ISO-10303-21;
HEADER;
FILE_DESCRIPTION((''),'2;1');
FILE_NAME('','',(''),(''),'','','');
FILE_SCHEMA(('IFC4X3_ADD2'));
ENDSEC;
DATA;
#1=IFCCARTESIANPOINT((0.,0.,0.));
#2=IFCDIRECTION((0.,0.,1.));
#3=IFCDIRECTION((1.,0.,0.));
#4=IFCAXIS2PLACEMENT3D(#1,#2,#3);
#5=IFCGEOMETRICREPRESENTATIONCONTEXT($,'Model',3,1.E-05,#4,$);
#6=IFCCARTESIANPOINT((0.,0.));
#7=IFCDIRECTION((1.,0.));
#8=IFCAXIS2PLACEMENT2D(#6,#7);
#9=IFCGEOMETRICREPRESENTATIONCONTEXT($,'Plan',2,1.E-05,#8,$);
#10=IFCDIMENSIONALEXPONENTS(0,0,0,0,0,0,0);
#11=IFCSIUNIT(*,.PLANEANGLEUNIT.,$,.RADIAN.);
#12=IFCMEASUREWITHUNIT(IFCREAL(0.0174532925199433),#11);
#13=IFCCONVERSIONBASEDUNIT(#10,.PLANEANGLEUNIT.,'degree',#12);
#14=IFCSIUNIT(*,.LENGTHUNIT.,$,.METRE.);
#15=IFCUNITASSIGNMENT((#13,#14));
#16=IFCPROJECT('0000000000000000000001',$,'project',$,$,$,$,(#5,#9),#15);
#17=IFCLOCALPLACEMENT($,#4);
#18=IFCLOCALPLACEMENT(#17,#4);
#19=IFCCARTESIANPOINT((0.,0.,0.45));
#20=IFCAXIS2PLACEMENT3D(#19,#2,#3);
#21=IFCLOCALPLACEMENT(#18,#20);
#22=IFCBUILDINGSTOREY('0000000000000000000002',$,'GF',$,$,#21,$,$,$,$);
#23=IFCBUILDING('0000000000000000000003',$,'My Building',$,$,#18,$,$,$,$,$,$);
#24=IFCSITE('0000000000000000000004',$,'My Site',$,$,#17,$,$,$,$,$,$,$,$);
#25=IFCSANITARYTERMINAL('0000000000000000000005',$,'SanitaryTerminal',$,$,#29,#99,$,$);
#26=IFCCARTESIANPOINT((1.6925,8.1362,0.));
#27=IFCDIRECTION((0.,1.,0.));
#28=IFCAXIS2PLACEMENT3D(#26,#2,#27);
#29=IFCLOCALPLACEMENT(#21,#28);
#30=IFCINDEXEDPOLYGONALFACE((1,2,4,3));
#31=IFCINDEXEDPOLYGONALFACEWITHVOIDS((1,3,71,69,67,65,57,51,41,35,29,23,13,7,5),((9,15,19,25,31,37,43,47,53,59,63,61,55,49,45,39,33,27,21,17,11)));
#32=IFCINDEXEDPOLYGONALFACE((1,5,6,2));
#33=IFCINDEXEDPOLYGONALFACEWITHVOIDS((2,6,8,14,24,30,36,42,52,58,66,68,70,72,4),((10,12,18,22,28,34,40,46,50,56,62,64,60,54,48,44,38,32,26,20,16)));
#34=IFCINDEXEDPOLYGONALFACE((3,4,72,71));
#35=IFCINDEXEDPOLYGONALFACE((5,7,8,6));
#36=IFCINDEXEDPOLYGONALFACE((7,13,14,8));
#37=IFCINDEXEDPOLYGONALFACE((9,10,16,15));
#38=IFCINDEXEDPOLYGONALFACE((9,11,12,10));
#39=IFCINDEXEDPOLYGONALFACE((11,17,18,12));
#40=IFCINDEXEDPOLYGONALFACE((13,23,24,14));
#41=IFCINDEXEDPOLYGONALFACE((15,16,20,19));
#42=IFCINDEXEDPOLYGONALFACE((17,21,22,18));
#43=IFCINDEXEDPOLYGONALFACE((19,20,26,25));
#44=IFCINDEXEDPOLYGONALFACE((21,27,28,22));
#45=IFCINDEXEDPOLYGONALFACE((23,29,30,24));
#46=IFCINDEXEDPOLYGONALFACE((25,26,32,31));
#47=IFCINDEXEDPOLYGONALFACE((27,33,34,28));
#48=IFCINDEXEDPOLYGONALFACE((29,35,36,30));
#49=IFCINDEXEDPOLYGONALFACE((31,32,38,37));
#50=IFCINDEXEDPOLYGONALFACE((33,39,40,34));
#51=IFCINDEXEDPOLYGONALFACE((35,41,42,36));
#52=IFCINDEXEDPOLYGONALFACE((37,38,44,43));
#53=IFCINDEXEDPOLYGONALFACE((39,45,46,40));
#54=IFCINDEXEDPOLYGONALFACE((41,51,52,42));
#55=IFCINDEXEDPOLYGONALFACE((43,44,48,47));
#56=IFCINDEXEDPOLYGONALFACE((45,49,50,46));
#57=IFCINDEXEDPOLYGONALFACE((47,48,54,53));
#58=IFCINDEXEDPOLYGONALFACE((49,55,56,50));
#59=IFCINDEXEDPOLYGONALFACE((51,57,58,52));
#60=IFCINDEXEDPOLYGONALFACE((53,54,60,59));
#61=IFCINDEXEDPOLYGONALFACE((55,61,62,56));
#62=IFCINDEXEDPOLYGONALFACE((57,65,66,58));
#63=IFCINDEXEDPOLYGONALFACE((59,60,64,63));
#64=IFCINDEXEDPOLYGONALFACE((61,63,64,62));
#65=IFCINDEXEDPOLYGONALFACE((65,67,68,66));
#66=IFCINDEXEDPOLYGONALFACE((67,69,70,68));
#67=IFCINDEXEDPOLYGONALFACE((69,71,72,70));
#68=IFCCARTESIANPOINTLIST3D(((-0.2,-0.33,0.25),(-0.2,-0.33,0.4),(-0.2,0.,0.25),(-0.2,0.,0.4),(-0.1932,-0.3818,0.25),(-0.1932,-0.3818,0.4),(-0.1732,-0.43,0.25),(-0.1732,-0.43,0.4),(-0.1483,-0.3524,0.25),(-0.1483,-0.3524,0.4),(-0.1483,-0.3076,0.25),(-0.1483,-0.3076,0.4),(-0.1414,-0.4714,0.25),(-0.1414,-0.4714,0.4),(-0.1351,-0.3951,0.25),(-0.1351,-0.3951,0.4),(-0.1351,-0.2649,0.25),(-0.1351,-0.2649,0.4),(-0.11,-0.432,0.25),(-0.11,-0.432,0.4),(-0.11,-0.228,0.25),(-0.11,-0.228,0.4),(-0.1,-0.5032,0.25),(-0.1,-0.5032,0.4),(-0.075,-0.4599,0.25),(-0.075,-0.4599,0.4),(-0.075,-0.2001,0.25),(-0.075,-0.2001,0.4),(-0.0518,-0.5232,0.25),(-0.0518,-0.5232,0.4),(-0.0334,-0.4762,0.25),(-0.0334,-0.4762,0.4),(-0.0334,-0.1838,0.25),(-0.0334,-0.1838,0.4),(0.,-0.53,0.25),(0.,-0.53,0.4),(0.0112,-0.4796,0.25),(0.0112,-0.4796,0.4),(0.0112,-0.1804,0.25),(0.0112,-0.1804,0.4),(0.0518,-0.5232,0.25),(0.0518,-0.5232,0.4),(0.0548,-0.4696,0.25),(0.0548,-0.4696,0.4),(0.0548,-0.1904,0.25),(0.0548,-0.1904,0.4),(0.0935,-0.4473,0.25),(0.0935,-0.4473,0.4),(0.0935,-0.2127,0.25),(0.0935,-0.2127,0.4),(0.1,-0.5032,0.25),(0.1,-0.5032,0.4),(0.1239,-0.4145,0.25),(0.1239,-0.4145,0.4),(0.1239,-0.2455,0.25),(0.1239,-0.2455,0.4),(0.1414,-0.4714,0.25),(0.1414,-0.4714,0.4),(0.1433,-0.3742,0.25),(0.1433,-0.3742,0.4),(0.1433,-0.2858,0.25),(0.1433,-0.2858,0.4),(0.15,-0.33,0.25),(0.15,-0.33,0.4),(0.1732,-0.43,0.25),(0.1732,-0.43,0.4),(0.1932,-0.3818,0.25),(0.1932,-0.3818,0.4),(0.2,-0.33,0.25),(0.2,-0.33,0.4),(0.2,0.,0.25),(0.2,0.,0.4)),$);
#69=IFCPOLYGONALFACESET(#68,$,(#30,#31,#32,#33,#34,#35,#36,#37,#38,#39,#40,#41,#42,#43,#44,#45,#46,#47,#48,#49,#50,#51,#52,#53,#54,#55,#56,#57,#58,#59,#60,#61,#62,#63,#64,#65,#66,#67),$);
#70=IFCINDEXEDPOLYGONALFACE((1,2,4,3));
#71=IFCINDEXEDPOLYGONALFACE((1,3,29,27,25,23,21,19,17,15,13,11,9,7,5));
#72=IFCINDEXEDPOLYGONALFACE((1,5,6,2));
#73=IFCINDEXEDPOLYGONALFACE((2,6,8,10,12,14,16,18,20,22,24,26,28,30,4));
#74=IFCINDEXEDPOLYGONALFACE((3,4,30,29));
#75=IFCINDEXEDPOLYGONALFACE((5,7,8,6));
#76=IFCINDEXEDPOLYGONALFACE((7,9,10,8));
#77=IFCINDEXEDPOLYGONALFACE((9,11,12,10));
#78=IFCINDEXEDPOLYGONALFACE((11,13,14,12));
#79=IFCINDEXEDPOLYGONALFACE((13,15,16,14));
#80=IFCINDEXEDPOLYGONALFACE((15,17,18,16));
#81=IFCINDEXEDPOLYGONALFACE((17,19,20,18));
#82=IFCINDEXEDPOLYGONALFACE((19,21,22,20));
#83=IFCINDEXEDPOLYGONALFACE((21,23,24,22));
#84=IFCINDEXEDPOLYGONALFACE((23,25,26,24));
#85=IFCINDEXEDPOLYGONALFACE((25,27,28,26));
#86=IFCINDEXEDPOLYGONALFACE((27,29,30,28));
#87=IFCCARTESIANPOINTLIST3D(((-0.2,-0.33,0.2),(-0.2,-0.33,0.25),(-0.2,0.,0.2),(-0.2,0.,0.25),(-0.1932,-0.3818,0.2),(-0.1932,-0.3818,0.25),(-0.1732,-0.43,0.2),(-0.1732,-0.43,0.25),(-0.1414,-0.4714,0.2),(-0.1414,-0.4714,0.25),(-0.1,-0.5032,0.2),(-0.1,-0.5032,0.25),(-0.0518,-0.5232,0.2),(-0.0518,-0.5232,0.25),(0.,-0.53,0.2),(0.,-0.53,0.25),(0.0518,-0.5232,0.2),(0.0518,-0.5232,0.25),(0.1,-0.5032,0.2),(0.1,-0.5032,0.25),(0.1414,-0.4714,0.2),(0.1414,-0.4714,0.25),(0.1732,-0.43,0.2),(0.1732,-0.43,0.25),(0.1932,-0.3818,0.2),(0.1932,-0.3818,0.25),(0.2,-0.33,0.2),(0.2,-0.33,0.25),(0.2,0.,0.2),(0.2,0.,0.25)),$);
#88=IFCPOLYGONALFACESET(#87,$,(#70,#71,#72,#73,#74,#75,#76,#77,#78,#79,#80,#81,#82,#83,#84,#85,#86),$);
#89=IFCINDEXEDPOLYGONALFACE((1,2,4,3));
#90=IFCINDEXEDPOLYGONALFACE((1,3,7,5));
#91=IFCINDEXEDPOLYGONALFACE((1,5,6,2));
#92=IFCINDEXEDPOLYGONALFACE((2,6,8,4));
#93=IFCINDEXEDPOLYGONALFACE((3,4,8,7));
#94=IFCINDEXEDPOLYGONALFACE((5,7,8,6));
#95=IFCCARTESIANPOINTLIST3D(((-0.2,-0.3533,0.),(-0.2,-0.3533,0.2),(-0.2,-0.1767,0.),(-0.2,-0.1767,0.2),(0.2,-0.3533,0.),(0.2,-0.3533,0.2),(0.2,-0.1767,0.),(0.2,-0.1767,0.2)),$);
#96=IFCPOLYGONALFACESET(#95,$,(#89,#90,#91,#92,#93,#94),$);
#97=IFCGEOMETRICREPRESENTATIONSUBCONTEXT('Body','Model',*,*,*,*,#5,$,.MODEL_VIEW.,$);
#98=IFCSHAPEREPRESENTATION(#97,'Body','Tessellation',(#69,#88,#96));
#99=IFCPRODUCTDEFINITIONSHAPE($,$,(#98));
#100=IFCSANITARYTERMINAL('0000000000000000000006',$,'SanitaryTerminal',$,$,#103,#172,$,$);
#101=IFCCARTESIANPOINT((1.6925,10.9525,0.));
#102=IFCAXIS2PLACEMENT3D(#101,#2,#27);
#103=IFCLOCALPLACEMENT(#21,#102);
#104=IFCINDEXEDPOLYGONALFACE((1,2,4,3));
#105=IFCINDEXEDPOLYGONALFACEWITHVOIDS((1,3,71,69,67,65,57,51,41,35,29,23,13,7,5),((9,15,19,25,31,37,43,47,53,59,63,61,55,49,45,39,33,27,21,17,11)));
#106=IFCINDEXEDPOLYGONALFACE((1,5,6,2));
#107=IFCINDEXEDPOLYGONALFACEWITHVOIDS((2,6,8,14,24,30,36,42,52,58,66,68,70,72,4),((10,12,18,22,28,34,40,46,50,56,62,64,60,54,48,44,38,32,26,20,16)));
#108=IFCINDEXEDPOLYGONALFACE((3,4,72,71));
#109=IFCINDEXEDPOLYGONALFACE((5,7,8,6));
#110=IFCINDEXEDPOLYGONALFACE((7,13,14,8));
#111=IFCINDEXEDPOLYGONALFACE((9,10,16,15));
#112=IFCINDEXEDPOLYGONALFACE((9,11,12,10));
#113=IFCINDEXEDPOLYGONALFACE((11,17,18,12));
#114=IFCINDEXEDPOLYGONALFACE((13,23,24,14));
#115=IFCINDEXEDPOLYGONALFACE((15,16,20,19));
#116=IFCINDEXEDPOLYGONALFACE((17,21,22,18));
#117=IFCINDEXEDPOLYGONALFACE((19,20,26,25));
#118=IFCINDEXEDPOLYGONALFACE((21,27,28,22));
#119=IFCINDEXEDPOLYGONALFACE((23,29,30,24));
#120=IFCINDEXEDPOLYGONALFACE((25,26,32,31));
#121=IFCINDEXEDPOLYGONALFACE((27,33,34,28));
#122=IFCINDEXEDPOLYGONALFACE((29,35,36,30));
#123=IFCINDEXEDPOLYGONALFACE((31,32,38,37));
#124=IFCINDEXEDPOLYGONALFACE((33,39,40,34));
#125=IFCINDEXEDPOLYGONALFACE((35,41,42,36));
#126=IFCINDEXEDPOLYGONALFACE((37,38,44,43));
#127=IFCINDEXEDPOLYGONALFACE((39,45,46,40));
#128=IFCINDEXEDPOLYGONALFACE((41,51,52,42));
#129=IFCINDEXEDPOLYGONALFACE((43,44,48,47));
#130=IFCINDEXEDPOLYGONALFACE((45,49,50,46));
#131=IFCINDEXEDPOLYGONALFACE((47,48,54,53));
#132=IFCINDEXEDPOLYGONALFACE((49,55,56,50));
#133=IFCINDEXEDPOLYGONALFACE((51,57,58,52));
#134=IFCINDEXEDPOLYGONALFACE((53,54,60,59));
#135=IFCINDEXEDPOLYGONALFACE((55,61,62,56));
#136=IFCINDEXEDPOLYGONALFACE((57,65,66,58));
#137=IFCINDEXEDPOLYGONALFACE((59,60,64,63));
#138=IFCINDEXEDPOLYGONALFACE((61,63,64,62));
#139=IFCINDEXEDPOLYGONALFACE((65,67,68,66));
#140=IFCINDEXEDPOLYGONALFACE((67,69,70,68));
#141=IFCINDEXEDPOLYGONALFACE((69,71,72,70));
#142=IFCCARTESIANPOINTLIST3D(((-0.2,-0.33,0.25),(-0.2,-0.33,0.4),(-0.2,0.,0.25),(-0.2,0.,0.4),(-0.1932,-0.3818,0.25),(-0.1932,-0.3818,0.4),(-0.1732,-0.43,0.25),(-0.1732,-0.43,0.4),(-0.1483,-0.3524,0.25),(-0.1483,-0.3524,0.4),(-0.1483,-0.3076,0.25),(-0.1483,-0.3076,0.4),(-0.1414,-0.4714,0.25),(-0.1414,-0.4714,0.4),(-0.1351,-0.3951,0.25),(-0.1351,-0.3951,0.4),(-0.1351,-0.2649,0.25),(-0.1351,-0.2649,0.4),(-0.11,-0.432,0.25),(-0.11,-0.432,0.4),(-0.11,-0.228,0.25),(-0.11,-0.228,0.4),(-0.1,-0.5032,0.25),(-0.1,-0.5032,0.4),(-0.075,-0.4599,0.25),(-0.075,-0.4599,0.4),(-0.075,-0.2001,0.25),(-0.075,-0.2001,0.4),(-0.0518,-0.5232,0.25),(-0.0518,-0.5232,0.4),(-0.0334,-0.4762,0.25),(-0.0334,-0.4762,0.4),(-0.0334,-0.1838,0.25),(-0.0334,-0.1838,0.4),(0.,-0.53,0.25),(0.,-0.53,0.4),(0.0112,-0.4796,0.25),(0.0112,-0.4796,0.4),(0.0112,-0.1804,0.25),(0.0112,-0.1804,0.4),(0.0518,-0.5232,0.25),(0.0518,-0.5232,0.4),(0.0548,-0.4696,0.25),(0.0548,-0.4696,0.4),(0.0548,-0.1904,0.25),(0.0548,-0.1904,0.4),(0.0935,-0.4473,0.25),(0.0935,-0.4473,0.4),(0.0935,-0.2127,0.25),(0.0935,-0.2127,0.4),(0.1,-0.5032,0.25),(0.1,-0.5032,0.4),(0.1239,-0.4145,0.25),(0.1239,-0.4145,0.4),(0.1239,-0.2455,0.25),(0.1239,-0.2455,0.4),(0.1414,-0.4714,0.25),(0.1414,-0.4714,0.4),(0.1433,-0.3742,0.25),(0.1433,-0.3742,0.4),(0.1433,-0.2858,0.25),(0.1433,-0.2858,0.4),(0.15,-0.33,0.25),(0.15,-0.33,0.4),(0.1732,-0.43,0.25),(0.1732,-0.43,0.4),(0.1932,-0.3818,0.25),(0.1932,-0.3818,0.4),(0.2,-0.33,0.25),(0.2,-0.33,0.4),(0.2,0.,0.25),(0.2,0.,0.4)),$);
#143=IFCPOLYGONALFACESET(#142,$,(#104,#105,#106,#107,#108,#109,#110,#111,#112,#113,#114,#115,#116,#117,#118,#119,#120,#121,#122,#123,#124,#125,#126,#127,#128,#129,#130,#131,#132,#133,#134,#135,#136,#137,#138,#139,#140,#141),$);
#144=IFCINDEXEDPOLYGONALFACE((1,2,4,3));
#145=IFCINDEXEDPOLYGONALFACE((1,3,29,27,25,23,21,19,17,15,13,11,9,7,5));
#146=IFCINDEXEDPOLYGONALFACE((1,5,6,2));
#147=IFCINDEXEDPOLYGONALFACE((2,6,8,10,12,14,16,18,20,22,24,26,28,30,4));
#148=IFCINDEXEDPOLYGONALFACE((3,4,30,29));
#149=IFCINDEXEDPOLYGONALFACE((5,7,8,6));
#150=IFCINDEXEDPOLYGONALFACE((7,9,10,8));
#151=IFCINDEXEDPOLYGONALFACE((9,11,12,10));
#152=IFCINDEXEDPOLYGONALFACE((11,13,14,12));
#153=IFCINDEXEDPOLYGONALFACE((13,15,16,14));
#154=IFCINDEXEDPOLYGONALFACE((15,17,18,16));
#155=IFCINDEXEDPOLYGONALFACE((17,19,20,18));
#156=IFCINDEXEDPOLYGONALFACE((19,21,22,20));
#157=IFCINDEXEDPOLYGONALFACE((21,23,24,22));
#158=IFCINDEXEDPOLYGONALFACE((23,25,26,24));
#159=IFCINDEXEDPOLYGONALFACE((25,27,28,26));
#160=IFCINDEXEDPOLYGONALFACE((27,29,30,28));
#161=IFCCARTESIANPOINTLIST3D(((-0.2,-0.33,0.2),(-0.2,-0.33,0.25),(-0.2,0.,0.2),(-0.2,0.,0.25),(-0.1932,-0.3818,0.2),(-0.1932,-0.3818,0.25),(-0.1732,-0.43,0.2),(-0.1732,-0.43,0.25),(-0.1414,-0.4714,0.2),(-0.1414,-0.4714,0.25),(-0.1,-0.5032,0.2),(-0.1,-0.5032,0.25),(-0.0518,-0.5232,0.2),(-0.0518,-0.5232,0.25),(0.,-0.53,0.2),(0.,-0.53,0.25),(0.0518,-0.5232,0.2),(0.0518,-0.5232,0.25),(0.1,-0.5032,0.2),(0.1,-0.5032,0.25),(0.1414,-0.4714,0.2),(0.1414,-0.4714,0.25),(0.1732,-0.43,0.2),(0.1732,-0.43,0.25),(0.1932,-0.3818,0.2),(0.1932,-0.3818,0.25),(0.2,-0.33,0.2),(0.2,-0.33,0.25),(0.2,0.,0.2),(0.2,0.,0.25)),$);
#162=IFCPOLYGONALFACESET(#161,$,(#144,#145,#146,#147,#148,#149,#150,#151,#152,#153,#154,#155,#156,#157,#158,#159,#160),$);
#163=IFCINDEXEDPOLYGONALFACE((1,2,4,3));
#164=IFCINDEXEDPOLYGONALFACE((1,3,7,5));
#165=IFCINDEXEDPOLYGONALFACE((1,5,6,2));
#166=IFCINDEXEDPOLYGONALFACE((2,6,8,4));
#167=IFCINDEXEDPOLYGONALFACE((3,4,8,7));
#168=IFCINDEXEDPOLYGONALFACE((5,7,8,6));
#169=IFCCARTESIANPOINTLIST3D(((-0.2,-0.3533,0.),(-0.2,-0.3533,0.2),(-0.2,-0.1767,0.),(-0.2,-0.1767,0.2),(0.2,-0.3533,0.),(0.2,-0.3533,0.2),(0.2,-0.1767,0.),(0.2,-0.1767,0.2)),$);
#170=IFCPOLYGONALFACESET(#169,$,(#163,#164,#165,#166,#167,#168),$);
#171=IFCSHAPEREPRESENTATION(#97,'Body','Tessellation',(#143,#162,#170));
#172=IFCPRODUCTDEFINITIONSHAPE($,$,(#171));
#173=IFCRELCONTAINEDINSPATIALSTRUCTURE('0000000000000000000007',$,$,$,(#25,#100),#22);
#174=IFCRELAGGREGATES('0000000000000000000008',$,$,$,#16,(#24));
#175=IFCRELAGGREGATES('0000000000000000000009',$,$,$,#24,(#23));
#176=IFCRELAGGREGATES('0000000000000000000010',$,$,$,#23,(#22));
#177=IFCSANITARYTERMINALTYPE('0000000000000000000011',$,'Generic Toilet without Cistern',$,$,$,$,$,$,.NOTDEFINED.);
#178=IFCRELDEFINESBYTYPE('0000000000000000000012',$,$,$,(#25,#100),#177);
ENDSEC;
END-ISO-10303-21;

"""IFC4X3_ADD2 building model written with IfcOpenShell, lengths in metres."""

from ifc_helpers import new_model, entity, si_unit, converted_unit, frame, frame_2d, origin_with_axes, origin_2d_with_axis, place, context, subcontext, project, spatial, line, arc, indexed_curve, circle_curve, outline, extrude, shape, source, transform, mapped, type_object, type_shapes, element, save


model = new_model("IFC4X3_ADD2")

# Units and contexts
model_context = context("Model", 3, precision=1e-05, world=origin_with_axes())
plan_context = context("Plan", 2, precision=1e-05, world=origin_2d_with_axis())
body_context_1 = subcontext(model_context, "Body", "Model", "MODEL_VIEW")
body_context_2 = subcontext(plan_context, "Body", "Plan", "PLAN_VIEW")
ifc_project = project(units=[converted_unit("PLANEANGLEUNIT", "degree", entity("IfcReal", 0.0174532925199433), si_unit("PLANEANGLEUNIT", "RADIAN"), dimensions=[0, 0, 0, 0, 0, 0, 0]), si_unit("LENGTHUNIT", "METRE")], contexts=[model_context, plan_context])

# Site, building, storey
site_placement = place(None, origin_with_axes())
site = spatial("IfcSite", under=ifc_project, at=site_placement, Name="My Site")
building_placement = place(site_placement, origin_with_axes())
building = spatial("IfcBuilding", under=site, at=building_placement, Name="My Building")
storey_placement = place(building_placement, frame((0.0, 0.0, 0.45), z_axis=(0.0, 0.0, 1.0), x_axis=(1.0, 0.0, 0.0)))
storey = spatial("IfcBuildingStorey", under=building, at=storey_placement, Name="GF")

# Sanitary terminals
sanitary_terminal_type_1 = type_object("IfcSanitaryTerminalType", Name="Generic Toilet without Cistern", PredefinedType="NOTDEFINED")
shared_shape_1 = source(origin_with_axes(), body_context_1, "Body", "SweptSolid", [
    extrude(outline(indexed_curve([(-0.2, 0.0), (0.2, 0.0), (0.2, -0.33), (0.1414, -0.4714), (0.0, -0.53), (-0.1414, -0.4714), (-0.2, -0.33)], segments=[line(1, 2), line(2, 3), arc(3, 4, 5), arc(5, 6, 7), line(7, 1)]), holes=[circle_curve(frame_2d((0.0, -0.33)), 0.15)]), frame((0.0, 0.0, 0.25), z_axis=(0.0, 0.0, 1.0), x_axis=(1.0, 0.0, 0.0)), (0.0, 0.0, 1.0), 0.15),
    extrude(outline(indexed_curve([(-0.2, 0.0), (0.2, 0.0), (0.2, -0.33), (0.1414, -0.4714), (0.0, -0.53), (-0.1414, -0.4714), (-0.2, -0.33)], segments=[line(1, 2), line(2, 3), arc(3, 4, 5), arc(5, 6, 7), line(7, 1)])), frame((0.0, 0.0, 0.2), z_axis=(0.0, 0.0, 1.0), x_axis=(1.0, 0.0, 0.0)), (0.0, 0.0, 1.0), 0.05),
    extrude(outline(indexed_curve([(-0.2, -0.1767), (0.2, -0.1767), (0.2, -0.3533), (-0.2, -0.3533)], segments=[line(1, 2, 3, 4, 1)])), origin_with_axes(), (0.0, 0.0, 1.0), 0.2),
])
shared_shape_2 = source(origin_with_axes(), body_context_2, "Body", "Annotation2D", [
    entity("IfcGeometricCurveSet", [entity("IfcIndexedPolyCurve", entity("IfcCartesianPointList2D", [[-0.1068, -0.124], [-0.0957, -0.1129], [-0.0804, -0.1088], [0.0804, -0.1088], [0.0957, -0.1129], [0.1068, -0.124], [0.1109, -0.1393], [0.1109, -0.3476], [0.1025, -0.3926], [0.0784, -0.4308], [0.0424, -0.4563], [0.0, -0.4652], [-0.0424, -0.4563], [-0.0784, -0.4308], [-0.1025, -0.3926], [-0.1109, -0.3476], [-0.1109, -0.1393]]), [entity("IfcLineIndex", [1, 2, 3, 4, 5, 6, 7, 8, 9, 10, 11, 12, 13, 14, 15, 16, 17, 1])]), entity("IfcIndexedPolyCurve", entity("IfcCartesianPointList2D", [[-0.1962, -0.2314], [-0.1848, -0.301], [-0.1764, -0.3339], [-0.1663, -0.3651], [-0.1546, -0.3944], [-0.1414, -0.4213], [-0.1269, -0.4458], [-0.1111, -0.4675], [-0.0943, -0.4862], [-0.0765, -0.5018], [-0.0581, -0.514], [-0.039, -0.5229], [-0.0196, -0.5282], [0.0, -0.53], [0.0196, -0.5282], [0.039, -0.5229], [0.0581, -0.514], [0.0765, -0.5018], [0.0943, -0.4862], [0.1111, -0.4675], [0.1269, -0.4458], [0.1414, -0.4213], [0.1546, -0.3944], [0.1663, -0.3651], [0.1764, -0.3339], [0.1848, -0.301], [0.1962, -0.2314], [0.2, -0.159], [0.1872, 0.0], [-0.1872, 0.0], [-0.2, -0.159]]), [entity("IfcLineIndex", [1, 2, 3, 4, 5, 6, 7, 8, 9, 10, 11, 12, 13, 14, 15, 16, 17, 18, 19, 20, 21, 22, 23, 24, 25, 26, 27, 28, 29, 30, 31, 1])])]),
])
type_shapes(sanitary_terminal_type_1, [shared_shape_1, shared_shape_2])
for number, where, z_axis, x_axis, name in (
    (1, (1.6925, 8.1362, 0.0), (0.0, 0.0, 1.0), (0.0, 1.0, 0.0), "SanitaryTerminal"),
    (2, (1.6925, 10.9525, 0.0), (0.0, 0.0, 1.0), (0.0, 1.0, 0.0), "SanitaryTerminal"),
):
    element("IfcSanitaryTerminal", number, at=place(storey_placement, frame(where, z_axis=z_axis, x_axis=x_axis)), inside=storey, type_object=sanitary_terminal_type_1, Name=name, shapes=[
        shape(body_context_1, "Body", "MappedRepresentation", [mapped(shared_shape_1, transform((0.0, 0.0, 0.0), x_axis=(1.0, 0.0, 0.0), y_axis=(0.0, 1.0, 0.0), z_axis=(0.0, 0.0, 1.0), scale=1.0))]),
        shape(body_context_2, "Body", "MappedRepresentation", [mapped(shared_shape_2, transform((0.0, 0.0, 0.0), x_axis=(1.0, 0.0, 0.0), y_axis=(0.0, 1.0, 0.0), z_axis=(0.0, 0.0, 1.0), scale=1.0))]),
    ])

save(model, "model.ifc")
